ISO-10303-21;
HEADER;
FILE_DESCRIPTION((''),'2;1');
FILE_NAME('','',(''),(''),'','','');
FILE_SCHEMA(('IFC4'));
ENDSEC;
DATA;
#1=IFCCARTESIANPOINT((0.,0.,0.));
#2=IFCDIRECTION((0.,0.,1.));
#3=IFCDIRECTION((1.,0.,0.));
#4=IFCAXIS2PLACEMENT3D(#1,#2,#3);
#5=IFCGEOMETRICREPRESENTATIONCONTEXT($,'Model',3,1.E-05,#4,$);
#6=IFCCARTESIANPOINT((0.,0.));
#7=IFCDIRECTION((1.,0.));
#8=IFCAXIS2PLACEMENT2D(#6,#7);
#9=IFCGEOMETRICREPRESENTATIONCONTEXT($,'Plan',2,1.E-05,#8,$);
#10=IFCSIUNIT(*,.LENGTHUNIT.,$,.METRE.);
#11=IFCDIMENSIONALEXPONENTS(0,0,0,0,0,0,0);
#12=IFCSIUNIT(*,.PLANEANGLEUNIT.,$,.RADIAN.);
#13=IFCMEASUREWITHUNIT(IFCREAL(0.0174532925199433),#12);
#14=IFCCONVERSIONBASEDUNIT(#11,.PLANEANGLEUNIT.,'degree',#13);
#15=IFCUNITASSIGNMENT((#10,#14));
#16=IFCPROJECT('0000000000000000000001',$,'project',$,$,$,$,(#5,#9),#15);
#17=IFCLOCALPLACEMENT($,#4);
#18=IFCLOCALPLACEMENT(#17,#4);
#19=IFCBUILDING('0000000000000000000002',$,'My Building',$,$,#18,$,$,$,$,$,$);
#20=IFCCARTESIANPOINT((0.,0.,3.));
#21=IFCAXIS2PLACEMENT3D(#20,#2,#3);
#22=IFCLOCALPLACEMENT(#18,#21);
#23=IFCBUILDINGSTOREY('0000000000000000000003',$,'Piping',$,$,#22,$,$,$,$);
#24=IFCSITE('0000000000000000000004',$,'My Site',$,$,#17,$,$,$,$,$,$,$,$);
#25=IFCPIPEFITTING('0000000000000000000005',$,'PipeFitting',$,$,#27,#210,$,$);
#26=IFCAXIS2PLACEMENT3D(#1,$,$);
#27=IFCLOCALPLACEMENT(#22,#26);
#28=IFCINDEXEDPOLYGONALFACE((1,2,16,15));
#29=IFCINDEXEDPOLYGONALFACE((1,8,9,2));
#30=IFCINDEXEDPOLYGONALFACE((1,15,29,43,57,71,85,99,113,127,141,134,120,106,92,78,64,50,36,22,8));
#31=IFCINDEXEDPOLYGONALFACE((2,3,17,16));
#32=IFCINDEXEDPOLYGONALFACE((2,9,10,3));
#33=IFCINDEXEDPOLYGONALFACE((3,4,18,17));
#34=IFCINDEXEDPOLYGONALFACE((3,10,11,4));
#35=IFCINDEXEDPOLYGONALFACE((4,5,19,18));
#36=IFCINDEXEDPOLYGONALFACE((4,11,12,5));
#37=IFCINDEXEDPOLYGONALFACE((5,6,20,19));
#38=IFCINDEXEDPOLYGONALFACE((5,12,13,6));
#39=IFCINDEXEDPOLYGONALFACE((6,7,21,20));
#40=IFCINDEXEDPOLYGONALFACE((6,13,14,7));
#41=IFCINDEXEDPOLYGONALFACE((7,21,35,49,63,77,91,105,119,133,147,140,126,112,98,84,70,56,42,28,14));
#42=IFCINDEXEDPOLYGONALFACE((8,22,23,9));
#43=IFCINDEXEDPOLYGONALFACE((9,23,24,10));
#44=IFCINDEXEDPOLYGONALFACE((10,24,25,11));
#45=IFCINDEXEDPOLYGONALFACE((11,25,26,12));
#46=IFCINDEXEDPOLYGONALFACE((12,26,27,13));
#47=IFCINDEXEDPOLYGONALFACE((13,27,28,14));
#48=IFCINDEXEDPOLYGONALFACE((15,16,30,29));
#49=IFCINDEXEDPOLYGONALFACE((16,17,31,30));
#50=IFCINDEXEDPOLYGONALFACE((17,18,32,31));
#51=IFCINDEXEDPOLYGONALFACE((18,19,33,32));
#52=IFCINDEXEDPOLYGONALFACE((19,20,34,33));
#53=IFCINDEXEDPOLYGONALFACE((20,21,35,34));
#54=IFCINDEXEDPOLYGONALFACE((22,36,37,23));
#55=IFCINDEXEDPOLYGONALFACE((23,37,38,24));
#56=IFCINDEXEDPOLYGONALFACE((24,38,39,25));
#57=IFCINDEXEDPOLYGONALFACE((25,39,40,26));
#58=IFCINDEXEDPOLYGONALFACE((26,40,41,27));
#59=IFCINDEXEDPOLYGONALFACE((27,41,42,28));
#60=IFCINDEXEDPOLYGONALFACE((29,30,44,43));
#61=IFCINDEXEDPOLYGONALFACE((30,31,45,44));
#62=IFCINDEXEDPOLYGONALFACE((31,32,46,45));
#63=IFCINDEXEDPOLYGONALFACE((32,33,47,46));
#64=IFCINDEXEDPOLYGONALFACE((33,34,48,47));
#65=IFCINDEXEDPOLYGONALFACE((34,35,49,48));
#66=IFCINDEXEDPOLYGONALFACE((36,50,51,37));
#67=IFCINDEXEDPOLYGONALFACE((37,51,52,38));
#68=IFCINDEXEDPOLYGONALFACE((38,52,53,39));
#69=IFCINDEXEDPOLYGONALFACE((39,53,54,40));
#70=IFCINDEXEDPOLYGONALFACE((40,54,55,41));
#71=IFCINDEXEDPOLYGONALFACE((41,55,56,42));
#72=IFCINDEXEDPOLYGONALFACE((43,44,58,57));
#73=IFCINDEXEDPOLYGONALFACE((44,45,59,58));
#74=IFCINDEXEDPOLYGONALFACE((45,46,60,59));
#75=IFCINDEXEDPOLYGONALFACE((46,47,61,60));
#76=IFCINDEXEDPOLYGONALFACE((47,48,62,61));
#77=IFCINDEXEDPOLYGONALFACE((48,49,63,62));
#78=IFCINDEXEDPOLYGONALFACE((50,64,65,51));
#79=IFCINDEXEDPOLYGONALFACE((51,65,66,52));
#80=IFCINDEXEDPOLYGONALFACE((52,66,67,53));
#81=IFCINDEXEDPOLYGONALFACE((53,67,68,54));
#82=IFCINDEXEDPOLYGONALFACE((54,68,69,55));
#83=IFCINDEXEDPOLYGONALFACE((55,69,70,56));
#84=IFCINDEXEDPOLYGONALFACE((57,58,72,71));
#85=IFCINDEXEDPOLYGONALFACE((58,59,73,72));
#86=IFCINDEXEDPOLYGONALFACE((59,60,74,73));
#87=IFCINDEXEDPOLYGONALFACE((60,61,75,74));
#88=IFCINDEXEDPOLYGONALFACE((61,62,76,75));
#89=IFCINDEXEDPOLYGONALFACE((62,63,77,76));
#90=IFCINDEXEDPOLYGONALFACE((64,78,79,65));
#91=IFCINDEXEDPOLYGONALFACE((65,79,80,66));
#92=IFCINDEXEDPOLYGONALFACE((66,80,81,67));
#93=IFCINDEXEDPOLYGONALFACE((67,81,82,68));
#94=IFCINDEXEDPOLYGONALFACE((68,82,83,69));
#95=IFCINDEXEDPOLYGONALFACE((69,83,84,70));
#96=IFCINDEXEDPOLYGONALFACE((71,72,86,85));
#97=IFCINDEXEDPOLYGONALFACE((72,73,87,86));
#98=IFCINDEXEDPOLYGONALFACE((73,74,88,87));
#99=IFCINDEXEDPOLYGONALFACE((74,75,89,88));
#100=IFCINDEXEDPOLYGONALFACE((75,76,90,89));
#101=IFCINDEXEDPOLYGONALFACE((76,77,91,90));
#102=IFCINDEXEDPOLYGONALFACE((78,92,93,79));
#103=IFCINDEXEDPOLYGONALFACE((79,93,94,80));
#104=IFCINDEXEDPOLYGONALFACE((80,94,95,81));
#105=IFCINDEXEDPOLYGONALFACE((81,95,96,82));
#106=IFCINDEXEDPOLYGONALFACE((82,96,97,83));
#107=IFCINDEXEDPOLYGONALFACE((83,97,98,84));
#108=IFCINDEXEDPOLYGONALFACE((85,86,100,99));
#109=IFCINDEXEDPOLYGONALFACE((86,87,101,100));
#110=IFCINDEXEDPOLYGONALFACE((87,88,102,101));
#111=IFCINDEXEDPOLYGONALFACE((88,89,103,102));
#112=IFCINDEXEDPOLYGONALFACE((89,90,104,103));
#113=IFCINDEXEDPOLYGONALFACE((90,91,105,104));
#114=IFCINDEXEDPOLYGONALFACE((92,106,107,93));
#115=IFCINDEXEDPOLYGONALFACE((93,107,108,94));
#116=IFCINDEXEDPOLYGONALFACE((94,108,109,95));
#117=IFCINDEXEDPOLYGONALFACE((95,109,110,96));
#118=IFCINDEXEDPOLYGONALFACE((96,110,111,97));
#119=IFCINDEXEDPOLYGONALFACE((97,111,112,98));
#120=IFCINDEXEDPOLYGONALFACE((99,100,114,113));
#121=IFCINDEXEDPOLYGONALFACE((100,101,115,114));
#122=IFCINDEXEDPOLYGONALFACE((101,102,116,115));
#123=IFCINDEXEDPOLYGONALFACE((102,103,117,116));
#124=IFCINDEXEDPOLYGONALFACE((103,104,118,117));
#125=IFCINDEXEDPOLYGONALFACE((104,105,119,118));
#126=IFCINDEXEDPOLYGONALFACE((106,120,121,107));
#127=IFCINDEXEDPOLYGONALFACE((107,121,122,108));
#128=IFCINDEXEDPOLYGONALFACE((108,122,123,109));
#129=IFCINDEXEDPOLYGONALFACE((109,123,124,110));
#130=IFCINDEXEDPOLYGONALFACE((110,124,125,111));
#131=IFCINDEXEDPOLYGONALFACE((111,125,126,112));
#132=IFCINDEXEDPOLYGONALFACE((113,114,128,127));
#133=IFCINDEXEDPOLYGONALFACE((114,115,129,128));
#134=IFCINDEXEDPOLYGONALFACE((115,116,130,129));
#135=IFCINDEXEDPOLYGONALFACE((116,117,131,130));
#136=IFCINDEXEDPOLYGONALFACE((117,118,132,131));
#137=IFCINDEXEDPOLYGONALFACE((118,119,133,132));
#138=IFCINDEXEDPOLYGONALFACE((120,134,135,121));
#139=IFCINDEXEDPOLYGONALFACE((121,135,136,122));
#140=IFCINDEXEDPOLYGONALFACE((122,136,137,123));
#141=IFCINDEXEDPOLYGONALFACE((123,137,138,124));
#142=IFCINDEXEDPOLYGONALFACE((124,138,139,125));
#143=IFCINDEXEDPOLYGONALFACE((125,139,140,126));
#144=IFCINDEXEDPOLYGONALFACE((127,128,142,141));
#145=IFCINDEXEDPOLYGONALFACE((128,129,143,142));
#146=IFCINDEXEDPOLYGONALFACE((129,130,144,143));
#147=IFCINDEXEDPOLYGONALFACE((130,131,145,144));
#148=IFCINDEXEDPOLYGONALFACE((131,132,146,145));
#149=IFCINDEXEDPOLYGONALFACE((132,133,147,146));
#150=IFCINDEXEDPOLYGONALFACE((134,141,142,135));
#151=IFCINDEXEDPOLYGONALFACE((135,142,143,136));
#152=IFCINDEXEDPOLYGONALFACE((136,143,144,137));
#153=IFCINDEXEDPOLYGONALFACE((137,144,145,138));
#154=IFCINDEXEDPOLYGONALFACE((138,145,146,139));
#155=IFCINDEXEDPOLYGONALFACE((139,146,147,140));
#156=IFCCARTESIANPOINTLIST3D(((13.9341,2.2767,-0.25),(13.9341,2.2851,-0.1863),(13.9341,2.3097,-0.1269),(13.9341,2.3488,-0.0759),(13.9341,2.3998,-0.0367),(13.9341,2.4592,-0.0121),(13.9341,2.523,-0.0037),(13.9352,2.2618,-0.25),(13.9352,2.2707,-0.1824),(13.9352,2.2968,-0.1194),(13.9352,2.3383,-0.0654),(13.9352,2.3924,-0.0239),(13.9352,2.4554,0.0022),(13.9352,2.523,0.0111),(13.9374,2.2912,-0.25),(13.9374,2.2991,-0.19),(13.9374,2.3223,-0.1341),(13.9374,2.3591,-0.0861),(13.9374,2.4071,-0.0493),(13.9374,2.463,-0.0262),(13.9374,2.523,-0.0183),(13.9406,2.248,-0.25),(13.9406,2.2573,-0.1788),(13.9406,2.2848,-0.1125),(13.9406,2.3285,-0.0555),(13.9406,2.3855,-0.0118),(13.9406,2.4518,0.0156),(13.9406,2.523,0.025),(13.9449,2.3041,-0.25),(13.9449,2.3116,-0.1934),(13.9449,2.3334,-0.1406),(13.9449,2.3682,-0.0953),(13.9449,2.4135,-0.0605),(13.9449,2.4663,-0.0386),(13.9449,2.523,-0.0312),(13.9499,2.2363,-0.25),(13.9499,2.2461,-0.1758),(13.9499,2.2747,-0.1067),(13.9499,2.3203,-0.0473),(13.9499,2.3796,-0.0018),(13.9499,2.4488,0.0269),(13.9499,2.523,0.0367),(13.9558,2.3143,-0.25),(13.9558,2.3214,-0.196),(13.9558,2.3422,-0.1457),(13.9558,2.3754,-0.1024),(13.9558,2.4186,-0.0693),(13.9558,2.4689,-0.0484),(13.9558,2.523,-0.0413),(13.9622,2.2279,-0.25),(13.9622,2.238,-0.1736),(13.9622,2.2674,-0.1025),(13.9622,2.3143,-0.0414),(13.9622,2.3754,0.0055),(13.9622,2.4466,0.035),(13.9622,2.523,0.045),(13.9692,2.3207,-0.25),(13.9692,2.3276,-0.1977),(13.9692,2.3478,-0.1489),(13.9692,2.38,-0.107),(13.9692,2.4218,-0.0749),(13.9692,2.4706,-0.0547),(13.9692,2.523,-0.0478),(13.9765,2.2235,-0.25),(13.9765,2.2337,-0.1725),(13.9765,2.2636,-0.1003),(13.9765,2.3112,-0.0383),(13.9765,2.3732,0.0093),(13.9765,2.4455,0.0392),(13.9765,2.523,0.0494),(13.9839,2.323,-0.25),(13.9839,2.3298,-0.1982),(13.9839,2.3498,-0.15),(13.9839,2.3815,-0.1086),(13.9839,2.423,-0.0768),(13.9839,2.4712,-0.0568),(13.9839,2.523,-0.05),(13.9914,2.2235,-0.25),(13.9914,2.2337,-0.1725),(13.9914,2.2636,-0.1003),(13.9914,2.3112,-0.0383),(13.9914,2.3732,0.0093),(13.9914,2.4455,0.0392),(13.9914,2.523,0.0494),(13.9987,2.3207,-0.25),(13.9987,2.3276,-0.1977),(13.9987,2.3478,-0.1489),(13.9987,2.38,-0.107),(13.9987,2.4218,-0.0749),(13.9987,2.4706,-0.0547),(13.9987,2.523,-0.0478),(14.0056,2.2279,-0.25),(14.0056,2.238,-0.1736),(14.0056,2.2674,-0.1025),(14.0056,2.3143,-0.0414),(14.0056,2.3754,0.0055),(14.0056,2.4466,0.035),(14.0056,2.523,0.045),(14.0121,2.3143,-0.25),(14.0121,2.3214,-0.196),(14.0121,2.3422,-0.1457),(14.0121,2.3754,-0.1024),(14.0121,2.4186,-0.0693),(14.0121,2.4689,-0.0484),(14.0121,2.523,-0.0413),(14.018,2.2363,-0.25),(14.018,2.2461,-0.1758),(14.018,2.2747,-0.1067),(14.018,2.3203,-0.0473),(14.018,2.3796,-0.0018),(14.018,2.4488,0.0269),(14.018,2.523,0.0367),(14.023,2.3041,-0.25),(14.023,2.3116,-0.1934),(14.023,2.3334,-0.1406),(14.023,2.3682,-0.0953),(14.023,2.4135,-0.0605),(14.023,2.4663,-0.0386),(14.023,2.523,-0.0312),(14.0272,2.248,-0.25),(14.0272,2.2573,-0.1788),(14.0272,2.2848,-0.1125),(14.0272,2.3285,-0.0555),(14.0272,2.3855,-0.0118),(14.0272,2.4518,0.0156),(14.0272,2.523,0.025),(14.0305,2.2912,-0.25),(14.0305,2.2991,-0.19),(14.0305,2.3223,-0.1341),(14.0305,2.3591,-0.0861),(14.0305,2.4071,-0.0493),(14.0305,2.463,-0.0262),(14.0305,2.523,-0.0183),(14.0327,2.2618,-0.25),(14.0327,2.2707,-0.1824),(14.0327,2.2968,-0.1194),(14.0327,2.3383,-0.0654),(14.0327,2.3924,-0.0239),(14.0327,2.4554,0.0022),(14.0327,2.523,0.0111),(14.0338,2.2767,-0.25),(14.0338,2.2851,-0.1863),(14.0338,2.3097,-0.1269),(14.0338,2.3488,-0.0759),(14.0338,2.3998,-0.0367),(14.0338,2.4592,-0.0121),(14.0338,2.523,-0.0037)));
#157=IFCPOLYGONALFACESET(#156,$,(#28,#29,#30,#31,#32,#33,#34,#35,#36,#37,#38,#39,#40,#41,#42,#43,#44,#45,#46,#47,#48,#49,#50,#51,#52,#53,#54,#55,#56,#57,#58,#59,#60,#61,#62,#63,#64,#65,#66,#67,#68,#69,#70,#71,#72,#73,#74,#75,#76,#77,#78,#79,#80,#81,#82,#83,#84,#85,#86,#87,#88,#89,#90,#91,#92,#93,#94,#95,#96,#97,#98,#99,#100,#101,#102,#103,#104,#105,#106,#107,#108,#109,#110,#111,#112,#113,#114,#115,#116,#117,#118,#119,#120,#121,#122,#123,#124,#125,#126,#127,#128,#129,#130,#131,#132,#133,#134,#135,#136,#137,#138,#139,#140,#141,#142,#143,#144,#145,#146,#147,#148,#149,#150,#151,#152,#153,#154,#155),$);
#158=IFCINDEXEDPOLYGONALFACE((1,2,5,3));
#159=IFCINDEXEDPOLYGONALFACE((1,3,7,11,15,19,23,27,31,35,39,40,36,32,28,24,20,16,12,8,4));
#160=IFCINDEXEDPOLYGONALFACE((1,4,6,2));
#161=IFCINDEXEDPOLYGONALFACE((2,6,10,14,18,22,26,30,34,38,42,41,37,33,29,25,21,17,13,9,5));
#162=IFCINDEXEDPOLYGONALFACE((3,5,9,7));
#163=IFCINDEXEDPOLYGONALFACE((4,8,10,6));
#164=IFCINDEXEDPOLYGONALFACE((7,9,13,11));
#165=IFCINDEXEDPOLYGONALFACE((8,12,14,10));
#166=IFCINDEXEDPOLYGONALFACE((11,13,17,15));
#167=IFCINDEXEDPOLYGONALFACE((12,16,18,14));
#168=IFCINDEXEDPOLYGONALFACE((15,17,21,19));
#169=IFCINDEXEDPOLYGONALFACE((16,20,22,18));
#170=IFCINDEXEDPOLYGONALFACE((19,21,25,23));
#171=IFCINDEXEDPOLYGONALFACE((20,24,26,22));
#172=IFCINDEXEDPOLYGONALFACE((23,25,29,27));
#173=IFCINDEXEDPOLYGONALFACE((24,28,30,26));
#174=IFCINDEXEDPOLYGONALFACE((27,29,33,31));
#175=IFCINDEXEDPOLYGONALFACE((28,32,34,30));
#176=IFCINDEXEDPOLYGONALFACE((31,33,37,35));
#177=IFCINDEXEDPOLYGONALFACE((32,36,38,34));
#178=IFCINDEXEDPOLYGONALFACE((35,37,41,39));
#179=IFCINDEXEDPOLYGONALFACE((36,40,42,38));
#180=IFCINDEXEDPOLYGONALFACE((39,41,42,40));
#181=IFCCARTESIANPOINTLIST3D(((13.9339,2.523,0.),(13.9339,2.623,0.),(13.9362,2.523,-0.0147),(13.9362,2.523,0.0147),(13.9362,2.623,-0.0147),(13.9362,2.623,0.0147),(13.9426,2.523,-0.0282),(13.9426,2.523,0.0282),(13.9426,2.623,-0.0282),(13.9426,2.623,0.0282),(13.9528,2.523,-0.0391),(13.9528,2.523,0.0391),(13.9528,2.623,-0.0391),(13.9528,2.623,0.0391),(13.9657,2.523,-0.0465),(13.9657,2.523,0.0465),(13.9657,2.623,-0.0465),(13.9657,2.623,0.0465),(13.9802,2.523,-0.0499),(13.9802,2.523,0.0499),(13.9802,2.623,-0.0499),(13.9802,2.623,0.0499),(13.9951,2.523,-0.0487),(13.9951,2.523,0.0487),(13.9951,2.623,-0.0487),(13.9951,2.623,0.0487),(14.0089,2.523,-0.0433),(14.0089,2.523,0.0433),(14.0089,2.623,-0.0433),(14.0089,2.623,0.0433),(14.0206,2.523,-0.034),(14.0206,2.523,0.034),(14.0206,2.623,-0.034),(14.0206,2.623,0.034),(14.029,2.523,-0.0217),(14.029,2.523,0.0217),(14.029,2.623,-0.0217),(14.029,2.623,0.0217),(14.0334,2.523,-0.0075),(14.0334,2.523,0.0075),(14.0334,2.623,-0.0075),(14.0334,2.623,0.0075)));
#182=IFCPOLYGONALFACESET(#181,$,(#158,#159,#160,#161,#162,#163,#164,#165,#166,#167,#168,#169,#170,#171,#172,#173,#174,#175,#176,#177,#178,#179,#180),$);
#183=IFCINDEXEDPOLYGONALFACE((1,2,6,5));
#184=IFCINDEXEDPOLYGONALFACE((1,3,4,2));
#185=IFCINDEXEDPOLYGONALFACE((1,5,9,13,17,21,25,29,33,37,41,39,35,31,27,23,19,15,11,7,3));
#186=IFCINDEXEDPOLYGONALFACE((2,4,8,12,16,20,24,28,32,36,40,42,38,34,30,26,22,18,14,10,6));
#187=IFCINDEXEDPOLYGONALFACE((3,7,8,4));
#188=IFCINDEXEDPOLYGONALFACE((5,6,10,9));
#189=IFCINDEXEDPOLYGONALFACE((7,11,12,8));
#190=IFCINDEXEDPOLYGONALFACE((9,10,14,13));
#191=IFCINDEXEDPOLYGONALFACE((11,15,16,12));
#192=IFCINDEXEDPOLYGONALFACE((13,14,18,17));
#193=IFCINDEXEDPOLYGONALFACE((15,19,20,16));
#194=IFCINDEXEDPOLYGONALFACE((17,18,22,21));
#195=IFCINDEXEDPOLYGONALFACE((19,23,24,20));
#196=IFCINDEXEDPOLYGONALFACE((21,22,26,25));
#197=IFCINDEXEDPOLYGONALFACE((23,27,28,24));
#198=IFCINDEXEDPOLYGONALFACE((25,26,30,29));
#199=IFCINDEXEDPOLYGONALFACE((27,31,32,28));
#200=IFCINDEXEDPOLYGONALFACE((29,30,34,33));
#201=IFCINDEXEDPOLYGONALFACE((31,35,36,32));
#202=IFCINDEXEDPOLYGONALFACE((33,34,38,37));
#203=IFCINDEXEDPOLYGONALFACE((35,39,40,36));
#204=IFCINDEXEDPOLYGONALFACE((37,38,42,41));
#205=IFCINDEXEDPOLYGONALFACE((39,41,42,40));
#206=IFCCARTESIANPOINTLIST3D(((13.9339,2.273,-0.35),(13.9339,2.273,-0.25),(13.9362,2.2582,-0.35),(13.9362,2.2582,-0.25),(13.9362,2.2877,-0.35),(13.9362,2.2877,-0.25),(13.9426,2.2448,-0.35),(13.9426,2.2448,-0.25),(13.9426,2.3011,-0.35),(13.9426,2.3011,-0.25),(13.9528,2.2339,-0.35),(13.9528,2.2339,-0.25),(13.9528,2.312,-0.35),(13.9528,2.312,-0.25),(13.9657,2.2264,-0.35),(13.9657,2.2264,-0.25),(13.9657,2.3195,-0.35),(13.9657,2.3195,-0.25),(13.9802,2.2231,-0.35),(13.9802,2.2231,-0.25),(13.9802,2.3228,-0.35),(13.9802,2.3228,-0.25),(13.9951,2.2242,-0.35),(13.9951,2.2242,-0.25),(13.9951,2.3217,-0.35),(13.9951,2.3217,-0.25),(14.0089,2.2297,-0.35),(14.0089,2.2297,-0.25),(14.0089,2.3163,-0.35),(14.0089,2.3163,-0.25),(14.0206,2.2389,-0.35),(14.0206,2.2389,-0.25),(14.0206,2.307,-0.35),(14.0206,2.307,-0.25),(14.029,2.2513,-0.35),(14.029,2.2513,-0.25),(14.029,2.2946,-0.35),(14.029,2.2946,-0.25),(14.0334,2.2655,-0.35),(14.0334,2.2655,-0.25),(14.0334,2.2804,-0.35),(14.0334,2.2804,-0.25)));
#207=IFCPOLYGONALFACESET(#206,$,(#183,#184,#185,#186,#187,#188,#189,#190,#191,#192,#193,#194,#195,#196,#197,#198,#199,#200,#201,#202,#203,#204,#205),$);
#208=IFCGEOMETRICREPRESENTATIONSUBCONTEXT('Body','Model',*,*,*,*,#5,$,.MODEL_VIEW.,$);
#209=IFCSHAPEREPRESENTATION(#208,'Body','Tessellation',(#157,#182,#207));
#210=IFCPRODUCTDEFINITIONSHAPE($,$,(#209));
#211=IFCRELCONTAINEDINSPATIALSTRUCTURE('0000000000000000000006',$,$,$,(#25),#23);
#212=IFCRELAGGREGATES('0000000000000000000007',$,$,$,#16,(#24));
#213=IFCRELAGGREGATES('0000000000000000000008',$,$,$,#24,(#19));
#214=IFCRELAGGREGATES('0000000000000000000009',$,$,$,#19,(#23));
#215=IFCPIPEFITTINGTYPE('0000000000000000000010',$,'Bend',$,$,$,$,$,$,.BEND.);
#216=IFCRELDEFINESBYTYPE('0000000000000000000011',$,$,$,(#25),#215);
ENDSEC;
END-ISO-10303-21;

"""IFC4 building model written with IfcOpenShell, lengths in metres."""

from ifc_helpers import new_model, entity, si_unit, converted_unit, frame, origin_with_axes, origin_2d_with_axis, place, context, subcontext, project, spatial, circle, extrude, source, transform, mapped, type_object, type_shapes, element, save


model = new_model("IFC4")

# Units and contexts
model_context = context("Model", 3, precision=1e-05, world=origin_with_axes())
plan_context = context("Plan", 2, precision=1e-05, world=origin_2d_with_axis())
body_context = subcontext(model_context, "Body", "Model", "MODEL_VIEW")
ifc_project = project(units=[si_unit("LENGTHUNIT", "METRE"), converted_unit("PLANEANGLEUNIT", "degree", entity("IfcReal", 0.0174532925199433), si_unit("PLANEANGLEUNIT", "RADIAN"), dimensions=[0, 0, 0, 0, 0, 0, 0])], contexts=[model_context, plan_context])

# Site, building, storey
site_placement = place(None, origin_with_axes())
site = spatial("IfcSite", under=ifc_project, at=site_placement, Name="My Site")
building_placement = place(site_placement, origin_with_axes())
building = spatial("IfcBuilding", under=site, at=building_placement, Name="My Building")
storey_placement = place(building_placement, frame((0.0, 0.0, 3.0), z_axis=(0.0, 0.0, 1.0), x_axis=(1.0, 0.0, 0.0)))
storey = spatial("IfcBuildingStorey", under=building, at=storey_placement, Name="Piping")

# Pipe fitting
pipe_fitting_type = type_object("IfcPipeFittingType", Name="Bend", PredefinedType="BEND")
shared_shape = source(origin_with_axes(), body_context, "Body", "SolidModel", [
    entity("IfcSweptDiskSolid", entity("IfcIndexedPolyCurve", entity("IfcCartesianPointList3D", [[0.0, 0.0, -0.1], [0.0, -0.0732, -0.2768], [0.0, -0.25, -0.35]]), [entity("IfcArcIndex", [1, 2, 3])]), 0.05),
    extrude(circle(Radius=0.05), origin_with_axes(), (0.0, 0.0, -1.0), 0.1),
    extrude(circle(Radius=0.05), frame((0.0, -0.25, -0.35), z_axis=(0.0, -1.0, 0.0), x_axis=(1.0, 0.0, 0.0)), (0.0, 0.0, 1.0), 0.1),
])
type_shapes(pipe_fitting_type, [shared_shape])
for number, where, z_axis, x_axis, name in (
    (1, (13.9839, 2.623, 0.0), (0.0, 1.0, 0.0), (-1.0, 0.0, 0.0), "PipeFitting"),
):
    element("IfcPipeFitting", number, at=place(storey_placement, frame(where, z_axis=z_axis, x_axis=x_axis)), inside=storey, type_object=pipe_fitting_type, Name=name, context=body_context, shape_type="MappedRepresentation", body=[
        mapped(shared_shape, transform((0.0, 0.0, 0.0), x_axis=(1.0, 0.0, 0.0), y_axis=(0.0, 1.0, 0.0), z_axis=(0.0, 0.0, 1.0), scale=1.0)),
    ])

save(model, "model.ifc")
